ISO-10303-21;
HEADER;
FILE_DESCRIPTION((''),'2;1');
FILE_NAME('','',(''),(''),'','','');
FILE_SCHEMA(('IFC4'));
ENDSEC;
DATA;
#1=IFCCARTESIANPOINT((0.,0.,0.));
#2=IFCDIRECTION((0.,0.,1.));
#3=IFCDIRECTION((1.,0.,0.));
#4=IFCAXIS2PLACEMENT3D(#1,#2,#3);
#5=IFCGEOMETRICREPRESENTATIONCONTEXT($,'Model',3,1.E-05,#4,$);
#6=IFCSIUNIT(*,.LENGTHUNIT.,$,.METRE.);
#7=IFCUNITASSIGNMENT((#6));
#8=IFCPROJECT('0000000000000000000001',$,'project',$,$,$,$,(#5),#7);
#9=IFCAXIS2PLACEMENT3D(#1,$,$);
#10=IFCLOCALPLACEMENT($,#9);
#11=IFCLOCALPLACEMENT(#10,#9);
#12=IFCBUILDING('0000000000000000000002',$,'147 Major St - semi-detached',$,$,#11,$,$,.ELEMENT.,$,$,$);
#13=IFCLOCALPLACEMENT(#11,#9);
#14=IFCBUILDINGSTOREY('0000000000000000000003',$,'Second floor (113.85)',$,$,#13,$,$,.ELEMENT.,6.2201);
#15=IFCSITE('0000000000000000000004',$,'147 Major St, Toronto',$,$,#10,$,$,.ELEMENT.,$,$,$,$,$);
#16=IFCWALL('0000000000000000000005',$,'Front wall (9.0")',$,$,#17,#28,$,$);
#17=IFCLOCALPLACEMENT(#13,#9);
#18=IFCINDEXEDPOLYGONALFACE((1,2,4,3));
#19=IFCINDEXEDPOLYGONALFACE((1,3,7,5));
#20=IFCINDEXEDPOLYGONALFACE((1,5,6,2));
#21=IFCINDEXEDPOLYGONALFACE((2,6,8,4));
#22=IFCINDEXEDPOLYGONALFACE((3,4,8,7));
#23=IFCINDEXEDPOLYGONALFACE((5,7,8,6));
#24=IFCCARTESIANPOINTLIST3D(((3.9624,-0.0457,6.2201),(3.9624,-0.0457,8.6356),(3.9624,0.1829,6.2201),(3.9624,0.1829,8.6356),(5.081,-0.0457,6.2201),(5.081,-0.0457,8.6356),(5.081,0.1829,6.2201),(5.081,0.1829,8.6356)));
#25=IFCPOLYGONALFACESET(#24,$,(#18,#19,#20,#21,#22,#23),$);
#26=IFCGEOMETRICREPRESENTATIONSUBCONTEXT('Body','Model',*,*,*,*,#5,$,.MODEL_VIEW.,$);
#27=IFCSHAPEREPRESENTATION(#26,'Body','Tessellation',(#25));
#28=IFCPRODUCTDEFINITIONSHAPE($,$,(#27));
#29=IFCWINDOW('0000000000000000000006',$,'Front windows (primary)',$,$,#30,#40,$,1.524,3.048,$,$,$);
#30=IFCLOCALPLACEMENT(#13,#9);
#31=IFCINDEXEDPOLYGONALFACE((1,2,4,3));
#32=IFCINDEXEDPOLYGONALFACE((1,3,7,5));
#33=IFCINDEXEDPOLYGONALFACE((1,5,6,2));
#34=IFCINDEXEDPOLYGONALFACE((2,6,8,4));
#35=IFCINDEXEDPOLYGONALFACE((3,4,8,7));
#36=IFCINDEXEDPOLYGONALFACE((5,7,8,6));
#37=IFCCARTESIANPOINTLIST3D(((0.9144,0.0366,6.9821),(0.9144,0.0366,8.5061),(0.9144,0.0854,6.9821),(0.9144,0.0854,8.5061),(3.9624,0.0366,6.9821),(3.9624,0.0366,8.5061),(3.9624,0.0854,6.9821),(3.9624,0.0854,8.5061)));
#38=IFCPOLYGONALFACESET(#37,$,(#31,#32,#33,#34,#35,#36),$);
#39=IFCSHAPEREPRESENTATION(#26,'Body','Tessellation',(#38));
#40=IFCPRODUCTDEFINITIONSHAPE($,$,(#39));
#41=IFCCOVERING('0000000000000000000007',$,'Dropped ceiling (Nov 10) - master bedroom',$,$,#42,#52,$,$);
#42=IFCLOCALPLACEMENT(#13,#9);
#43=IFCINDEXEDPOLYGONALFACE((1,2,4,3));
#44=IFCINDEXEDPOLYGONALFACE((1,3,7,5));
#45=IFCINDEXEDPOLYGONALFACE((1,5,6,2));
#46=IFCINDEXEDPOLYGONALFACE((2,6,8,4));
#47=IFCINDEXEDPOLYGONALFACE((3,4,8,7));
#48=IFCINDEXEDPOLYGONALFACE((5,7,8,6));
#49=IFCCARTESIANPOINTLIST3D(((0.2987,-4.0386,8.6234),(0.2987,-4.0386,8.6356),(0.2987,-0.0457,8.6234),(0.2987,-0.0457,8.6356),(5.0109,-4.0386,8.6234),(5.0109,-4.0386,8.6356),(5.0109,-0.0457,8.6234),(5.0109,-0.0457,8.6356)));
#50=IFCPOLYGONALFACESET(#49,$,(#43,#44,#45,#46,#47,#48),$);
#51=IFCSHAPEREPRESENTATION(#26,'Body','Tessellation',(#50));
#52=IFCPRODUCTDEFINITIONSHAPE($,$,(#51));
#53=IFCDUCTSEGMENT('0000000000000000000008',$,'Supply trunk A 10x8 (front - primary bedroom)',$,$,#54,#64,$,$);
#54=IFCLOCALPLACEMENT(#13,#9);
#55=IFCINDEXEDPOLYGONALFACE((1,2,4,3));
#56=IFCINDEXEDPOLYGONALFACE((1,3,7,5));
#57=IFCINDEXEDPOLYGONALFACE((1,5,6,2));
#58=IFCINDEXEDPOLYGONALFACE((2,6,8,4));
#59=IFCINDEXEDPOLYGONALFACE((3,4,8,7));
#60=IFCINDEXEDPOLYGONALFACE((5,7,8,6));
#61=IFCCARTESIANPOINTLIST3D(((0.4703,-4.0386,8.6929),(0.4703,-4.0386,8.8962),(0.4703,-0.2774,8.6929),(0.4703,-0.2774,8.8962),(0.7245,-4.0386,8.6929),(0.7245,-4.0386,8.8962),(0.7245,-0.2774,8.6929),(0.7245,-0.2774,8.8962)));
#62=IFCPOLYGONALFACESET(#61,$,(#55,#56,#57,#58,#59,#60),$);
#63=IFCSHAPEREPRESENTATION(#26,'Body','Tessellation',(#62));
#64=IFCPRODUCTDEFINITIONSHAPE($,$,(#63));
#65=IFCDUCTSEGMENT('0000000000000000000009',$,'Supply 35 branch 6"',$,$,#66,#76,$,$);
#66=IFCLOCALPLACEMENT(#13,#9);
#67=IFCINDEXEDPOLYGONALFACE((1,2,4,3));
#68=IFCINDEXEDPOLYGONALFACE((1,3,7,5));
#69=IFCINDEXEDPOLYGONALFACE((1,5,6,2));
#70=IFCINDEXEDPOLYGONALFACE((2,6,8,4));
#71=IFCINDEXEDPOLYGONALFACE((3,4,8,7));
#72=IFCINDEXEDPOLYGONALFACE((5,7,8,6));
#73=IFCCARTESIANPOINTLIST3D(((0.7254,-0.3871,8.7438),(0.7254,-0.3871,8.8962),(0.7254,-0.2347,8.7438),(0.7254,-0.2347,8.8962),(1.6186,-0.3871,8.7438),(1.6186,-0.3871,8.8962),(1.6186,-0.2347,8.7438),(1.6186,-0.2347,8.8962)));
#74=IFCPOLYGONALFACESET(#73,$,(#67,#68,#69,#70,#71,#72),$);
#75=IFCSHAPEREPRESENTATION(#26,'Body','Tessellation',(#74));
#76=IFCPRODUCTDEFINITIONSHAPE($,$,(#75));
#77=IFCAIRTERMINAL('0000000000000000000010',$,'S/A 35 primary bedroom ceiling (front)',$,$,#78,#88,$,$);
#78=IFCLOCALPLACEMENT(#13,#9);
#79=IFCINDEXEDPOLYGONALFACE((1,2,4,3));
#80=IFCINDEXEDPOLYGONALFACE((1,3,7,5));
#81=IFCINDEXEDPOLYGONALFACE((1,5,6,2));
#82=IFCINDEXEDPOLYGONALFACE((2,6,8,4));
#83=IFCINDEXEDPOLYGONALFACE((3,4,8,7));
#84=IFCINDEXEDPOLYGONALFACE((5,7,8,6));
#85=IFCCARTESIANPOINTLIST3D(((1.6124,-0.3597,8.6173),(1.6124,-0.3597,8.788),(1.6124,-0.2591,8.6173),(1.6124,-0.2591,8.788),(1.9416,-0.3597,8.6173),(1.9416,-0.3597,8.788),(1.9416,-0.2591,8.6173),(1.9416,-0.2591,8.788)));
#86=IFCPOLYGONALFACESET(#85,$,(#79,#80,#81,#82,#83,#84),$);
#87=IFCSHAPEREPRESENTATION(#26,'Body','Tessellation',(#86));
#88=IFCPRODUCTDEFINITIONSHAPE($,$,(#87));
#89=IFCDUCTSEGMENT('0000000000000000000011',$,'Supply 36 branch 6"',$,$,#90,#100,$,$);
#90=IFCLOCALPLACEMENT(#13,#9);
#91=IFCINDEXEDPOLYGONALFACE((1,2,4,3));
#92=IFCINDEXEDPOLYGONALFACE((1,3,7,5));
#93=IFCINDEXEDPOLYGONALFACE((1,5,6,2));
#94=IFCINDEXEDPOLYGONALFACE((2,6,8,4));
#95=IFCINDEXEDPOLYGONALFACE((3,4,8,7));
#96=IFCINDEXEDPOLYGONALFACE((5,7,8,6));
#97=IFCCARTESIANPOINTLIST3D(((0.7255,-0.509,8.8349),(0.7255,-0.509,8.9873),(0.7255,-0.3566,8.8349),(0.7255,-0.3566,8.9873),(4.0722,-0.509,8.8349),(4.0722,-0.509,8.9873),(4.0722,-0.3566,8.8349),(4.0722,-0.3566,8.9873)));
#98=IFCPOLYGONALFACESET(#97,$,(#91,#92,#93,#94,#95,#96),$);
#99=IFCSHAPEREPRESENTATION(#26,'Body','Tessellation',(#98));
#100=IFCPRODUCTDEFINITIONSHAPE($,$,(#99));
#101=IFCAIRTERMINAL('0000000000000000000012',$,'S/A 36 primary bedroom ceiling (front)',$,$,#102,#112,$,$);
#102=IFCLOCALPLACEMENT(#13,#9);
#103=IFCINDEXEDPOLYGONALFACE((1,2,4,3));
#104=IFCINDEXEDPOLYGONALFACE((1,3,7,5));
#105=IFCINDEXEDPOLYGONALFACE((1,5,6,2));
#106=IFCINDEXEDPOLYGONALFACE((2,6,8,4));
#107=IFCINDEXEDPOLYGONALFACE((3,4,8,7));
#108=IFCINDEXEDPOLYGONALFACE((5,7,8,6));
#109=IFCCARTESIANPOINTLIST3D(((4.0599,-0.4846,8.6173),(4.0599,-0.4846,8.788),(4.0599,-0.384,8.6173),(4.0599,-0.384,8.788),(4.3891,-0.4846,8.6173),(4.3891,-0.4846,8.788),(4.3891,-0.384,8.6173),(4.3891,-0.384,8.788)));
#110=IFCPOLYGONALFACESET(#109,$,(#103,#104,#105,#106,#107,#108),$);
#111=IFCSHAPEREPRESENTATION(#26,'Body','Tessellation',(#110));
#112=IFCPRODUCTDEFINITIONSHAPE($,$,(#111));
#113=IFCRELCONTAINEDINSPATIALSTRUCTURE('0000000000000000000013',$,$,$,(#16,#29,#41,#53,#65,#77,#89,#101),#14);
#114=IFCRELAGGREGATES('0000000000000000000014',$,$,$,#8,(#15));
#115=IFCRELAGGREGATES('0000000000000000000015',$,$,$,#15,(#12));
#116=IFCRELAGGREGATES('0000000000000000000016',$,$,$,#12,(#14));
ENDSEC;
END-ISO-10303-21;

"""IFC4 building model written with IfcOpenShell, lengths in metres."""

from ifc_helpers import new_model, si_unit, frame, origin, origin_with_axes, place, context, subcontext, project, spatial, rectangle, extrude, element, save


model = new_model("IFC4")

# Units and contexts
model_context = context("Model", 3, precision=1e-05, world=origin_with_axes())
body_context = subcontext(model_context, "Body", "Model", "MODEL_VIEW")
ifc_project = project(units=[si_unit("LENGTHUNIT", "METRE")], contexts=[model_context])

# Site, building, storey
site_placement = place(None, origin())
site = spatial("IfcSite", under=ifc_project, at=site_placement, Name="147 Major St, Toronto", CompositionType="ELEMENT")
building_placement = place(site_placement, origin())
building = spatial("IfcBuilding", under=site, at=building_placement, Name="147 Major St - semi-detached", CompositionType="ELEMENT")
storey_placement = place(building_placement, origin())
storey = spatial("IfcBuildingStorey", under=building, at=storey_placement, Name="Second floor (113.85)", CompositionType="ELEMENT", Elevation=6.2201)

# Wall
wall_1_placement = place(storey_placement, frame((4.5217, 0.0686, 6.2201)))
element("IfcWall", 1, at=wall_1_placement, inside=storey, Name="Front wall (9.0\")", context=body_context, shape_type="SweptSolid", body=[
    extrude(rectangle(XDim=1.1186, YDim=0.2286), origin_with_axes(), (0.0, 0.0, 1.0), 2.4155),
])

# Window
window_placement = place(storey_placement, frame((2.4384, 0.061, 6.9821)))
element("IfcWindow", 2, at=window_placement, inside=storey, Name="Front windows (primary)", OverallHeight=1.524, OverallWidth=3.048, context=body_context, shape_type="SweptSolid", body=[
    extrude(rectangle(XDim=3.048, YDim=0.0488), origin_with_axes(), (0.0, 0.0, 1.0), 1.524),
])

# Covering
for number, where, name in (
    (3, (2.6548, -2.0422, 8.6234), "Dropped ceiling (Nov 10) - master bedroom"),
):
    element("IfcCovering", number, at=place(storey_placement, frame(where)), inside=storey, Name=name, context=body_context, shape_type="SweptSolid", body=[
        extrude(rectangle(XDim=4.7122, YDim=3.9929), origin_with_axes(), (0.0, 0.0, 1.0), 0.0122),
    ])

# Duct segments
duct_segment_1_placement = place(storey_placement, frame((0.5974, -2.158, 8.6929)))
element("IfcDuctSegment", 4, at=duct_segment_1_placement, inside=storey, Name="Supply trunk A 10x8 (front - primary bedroom)", context=body_context, shape_type="SweptSolid", body=[
    extrude(rectangle(XDim=0.2542, YDim=3.7612), origin_with_axes(), (0.0, 0.0, 1.0), 0.2033),
])
duct_segment_2_placement = place(storey_placement, frame((1.172, -0.3109, 8.7438)))
element("IfcDuctSegment", 5, at=duct_segment_2_placement, inside=storey, Name="Supply 35 branch 6\"", context=body_context, shape_type="SweptSolid", body=[
    extrude(rectangle(XDim=0.8931, YDim=0.1524), origin_with_axes(), (0.0, 0.0, 1.0), 0.1524),
])

# Air terminal
air_terminal_1_placement = place(storey_placement, frame((1.777, -0.3094, 8.6173)))
element("IfcAirTerminal", 6, at=air_terminal_1_placement, inside=storey, Name="S/A 35 primary bedroom ceiling (front)", context=body_context, shape_type="SweptSolid", body=[
    extrude(rectangle(XDim=0.3292, YDim=0.1006), origin_with_axes(), (0.0, 0.0, 1.0), 0.1707),
])

# Duct segment
duct_segment_3_placement = place(storey_placement, frame((2.3988, -0.4328, 8.8349)))
element("IfcDuctSegment", 7, at=duct_segment_3_placement, inside=storey, Name="Supply 36 branch 6\"", context=body_context, shape_type="SweptSolid", body=[
    extrude(rectangle(XDim=3.3467, YDim=0.1524), origin_with_axes(), (0.0, 0.0, 1.0), 0.1524),
])

# Air terminal
air_terminal_2_placement = place(storey_placement, frame((4.2245, -0.4343, 8.6173)))
element("IfcAirTerminal", 8, at=air_terminal_2_placement, inside=storey, Name="S/A 36 primary bedroom ceiling (front)", context=body_context, shape_type="SweptSolid", body=[
    extrude(rectangle(XDim=0.3292, YDim=0.1006), origin_with_axes(), (0.0, 0.0, 1.0), 0.1707),
])

save(model, "model.ifc")
